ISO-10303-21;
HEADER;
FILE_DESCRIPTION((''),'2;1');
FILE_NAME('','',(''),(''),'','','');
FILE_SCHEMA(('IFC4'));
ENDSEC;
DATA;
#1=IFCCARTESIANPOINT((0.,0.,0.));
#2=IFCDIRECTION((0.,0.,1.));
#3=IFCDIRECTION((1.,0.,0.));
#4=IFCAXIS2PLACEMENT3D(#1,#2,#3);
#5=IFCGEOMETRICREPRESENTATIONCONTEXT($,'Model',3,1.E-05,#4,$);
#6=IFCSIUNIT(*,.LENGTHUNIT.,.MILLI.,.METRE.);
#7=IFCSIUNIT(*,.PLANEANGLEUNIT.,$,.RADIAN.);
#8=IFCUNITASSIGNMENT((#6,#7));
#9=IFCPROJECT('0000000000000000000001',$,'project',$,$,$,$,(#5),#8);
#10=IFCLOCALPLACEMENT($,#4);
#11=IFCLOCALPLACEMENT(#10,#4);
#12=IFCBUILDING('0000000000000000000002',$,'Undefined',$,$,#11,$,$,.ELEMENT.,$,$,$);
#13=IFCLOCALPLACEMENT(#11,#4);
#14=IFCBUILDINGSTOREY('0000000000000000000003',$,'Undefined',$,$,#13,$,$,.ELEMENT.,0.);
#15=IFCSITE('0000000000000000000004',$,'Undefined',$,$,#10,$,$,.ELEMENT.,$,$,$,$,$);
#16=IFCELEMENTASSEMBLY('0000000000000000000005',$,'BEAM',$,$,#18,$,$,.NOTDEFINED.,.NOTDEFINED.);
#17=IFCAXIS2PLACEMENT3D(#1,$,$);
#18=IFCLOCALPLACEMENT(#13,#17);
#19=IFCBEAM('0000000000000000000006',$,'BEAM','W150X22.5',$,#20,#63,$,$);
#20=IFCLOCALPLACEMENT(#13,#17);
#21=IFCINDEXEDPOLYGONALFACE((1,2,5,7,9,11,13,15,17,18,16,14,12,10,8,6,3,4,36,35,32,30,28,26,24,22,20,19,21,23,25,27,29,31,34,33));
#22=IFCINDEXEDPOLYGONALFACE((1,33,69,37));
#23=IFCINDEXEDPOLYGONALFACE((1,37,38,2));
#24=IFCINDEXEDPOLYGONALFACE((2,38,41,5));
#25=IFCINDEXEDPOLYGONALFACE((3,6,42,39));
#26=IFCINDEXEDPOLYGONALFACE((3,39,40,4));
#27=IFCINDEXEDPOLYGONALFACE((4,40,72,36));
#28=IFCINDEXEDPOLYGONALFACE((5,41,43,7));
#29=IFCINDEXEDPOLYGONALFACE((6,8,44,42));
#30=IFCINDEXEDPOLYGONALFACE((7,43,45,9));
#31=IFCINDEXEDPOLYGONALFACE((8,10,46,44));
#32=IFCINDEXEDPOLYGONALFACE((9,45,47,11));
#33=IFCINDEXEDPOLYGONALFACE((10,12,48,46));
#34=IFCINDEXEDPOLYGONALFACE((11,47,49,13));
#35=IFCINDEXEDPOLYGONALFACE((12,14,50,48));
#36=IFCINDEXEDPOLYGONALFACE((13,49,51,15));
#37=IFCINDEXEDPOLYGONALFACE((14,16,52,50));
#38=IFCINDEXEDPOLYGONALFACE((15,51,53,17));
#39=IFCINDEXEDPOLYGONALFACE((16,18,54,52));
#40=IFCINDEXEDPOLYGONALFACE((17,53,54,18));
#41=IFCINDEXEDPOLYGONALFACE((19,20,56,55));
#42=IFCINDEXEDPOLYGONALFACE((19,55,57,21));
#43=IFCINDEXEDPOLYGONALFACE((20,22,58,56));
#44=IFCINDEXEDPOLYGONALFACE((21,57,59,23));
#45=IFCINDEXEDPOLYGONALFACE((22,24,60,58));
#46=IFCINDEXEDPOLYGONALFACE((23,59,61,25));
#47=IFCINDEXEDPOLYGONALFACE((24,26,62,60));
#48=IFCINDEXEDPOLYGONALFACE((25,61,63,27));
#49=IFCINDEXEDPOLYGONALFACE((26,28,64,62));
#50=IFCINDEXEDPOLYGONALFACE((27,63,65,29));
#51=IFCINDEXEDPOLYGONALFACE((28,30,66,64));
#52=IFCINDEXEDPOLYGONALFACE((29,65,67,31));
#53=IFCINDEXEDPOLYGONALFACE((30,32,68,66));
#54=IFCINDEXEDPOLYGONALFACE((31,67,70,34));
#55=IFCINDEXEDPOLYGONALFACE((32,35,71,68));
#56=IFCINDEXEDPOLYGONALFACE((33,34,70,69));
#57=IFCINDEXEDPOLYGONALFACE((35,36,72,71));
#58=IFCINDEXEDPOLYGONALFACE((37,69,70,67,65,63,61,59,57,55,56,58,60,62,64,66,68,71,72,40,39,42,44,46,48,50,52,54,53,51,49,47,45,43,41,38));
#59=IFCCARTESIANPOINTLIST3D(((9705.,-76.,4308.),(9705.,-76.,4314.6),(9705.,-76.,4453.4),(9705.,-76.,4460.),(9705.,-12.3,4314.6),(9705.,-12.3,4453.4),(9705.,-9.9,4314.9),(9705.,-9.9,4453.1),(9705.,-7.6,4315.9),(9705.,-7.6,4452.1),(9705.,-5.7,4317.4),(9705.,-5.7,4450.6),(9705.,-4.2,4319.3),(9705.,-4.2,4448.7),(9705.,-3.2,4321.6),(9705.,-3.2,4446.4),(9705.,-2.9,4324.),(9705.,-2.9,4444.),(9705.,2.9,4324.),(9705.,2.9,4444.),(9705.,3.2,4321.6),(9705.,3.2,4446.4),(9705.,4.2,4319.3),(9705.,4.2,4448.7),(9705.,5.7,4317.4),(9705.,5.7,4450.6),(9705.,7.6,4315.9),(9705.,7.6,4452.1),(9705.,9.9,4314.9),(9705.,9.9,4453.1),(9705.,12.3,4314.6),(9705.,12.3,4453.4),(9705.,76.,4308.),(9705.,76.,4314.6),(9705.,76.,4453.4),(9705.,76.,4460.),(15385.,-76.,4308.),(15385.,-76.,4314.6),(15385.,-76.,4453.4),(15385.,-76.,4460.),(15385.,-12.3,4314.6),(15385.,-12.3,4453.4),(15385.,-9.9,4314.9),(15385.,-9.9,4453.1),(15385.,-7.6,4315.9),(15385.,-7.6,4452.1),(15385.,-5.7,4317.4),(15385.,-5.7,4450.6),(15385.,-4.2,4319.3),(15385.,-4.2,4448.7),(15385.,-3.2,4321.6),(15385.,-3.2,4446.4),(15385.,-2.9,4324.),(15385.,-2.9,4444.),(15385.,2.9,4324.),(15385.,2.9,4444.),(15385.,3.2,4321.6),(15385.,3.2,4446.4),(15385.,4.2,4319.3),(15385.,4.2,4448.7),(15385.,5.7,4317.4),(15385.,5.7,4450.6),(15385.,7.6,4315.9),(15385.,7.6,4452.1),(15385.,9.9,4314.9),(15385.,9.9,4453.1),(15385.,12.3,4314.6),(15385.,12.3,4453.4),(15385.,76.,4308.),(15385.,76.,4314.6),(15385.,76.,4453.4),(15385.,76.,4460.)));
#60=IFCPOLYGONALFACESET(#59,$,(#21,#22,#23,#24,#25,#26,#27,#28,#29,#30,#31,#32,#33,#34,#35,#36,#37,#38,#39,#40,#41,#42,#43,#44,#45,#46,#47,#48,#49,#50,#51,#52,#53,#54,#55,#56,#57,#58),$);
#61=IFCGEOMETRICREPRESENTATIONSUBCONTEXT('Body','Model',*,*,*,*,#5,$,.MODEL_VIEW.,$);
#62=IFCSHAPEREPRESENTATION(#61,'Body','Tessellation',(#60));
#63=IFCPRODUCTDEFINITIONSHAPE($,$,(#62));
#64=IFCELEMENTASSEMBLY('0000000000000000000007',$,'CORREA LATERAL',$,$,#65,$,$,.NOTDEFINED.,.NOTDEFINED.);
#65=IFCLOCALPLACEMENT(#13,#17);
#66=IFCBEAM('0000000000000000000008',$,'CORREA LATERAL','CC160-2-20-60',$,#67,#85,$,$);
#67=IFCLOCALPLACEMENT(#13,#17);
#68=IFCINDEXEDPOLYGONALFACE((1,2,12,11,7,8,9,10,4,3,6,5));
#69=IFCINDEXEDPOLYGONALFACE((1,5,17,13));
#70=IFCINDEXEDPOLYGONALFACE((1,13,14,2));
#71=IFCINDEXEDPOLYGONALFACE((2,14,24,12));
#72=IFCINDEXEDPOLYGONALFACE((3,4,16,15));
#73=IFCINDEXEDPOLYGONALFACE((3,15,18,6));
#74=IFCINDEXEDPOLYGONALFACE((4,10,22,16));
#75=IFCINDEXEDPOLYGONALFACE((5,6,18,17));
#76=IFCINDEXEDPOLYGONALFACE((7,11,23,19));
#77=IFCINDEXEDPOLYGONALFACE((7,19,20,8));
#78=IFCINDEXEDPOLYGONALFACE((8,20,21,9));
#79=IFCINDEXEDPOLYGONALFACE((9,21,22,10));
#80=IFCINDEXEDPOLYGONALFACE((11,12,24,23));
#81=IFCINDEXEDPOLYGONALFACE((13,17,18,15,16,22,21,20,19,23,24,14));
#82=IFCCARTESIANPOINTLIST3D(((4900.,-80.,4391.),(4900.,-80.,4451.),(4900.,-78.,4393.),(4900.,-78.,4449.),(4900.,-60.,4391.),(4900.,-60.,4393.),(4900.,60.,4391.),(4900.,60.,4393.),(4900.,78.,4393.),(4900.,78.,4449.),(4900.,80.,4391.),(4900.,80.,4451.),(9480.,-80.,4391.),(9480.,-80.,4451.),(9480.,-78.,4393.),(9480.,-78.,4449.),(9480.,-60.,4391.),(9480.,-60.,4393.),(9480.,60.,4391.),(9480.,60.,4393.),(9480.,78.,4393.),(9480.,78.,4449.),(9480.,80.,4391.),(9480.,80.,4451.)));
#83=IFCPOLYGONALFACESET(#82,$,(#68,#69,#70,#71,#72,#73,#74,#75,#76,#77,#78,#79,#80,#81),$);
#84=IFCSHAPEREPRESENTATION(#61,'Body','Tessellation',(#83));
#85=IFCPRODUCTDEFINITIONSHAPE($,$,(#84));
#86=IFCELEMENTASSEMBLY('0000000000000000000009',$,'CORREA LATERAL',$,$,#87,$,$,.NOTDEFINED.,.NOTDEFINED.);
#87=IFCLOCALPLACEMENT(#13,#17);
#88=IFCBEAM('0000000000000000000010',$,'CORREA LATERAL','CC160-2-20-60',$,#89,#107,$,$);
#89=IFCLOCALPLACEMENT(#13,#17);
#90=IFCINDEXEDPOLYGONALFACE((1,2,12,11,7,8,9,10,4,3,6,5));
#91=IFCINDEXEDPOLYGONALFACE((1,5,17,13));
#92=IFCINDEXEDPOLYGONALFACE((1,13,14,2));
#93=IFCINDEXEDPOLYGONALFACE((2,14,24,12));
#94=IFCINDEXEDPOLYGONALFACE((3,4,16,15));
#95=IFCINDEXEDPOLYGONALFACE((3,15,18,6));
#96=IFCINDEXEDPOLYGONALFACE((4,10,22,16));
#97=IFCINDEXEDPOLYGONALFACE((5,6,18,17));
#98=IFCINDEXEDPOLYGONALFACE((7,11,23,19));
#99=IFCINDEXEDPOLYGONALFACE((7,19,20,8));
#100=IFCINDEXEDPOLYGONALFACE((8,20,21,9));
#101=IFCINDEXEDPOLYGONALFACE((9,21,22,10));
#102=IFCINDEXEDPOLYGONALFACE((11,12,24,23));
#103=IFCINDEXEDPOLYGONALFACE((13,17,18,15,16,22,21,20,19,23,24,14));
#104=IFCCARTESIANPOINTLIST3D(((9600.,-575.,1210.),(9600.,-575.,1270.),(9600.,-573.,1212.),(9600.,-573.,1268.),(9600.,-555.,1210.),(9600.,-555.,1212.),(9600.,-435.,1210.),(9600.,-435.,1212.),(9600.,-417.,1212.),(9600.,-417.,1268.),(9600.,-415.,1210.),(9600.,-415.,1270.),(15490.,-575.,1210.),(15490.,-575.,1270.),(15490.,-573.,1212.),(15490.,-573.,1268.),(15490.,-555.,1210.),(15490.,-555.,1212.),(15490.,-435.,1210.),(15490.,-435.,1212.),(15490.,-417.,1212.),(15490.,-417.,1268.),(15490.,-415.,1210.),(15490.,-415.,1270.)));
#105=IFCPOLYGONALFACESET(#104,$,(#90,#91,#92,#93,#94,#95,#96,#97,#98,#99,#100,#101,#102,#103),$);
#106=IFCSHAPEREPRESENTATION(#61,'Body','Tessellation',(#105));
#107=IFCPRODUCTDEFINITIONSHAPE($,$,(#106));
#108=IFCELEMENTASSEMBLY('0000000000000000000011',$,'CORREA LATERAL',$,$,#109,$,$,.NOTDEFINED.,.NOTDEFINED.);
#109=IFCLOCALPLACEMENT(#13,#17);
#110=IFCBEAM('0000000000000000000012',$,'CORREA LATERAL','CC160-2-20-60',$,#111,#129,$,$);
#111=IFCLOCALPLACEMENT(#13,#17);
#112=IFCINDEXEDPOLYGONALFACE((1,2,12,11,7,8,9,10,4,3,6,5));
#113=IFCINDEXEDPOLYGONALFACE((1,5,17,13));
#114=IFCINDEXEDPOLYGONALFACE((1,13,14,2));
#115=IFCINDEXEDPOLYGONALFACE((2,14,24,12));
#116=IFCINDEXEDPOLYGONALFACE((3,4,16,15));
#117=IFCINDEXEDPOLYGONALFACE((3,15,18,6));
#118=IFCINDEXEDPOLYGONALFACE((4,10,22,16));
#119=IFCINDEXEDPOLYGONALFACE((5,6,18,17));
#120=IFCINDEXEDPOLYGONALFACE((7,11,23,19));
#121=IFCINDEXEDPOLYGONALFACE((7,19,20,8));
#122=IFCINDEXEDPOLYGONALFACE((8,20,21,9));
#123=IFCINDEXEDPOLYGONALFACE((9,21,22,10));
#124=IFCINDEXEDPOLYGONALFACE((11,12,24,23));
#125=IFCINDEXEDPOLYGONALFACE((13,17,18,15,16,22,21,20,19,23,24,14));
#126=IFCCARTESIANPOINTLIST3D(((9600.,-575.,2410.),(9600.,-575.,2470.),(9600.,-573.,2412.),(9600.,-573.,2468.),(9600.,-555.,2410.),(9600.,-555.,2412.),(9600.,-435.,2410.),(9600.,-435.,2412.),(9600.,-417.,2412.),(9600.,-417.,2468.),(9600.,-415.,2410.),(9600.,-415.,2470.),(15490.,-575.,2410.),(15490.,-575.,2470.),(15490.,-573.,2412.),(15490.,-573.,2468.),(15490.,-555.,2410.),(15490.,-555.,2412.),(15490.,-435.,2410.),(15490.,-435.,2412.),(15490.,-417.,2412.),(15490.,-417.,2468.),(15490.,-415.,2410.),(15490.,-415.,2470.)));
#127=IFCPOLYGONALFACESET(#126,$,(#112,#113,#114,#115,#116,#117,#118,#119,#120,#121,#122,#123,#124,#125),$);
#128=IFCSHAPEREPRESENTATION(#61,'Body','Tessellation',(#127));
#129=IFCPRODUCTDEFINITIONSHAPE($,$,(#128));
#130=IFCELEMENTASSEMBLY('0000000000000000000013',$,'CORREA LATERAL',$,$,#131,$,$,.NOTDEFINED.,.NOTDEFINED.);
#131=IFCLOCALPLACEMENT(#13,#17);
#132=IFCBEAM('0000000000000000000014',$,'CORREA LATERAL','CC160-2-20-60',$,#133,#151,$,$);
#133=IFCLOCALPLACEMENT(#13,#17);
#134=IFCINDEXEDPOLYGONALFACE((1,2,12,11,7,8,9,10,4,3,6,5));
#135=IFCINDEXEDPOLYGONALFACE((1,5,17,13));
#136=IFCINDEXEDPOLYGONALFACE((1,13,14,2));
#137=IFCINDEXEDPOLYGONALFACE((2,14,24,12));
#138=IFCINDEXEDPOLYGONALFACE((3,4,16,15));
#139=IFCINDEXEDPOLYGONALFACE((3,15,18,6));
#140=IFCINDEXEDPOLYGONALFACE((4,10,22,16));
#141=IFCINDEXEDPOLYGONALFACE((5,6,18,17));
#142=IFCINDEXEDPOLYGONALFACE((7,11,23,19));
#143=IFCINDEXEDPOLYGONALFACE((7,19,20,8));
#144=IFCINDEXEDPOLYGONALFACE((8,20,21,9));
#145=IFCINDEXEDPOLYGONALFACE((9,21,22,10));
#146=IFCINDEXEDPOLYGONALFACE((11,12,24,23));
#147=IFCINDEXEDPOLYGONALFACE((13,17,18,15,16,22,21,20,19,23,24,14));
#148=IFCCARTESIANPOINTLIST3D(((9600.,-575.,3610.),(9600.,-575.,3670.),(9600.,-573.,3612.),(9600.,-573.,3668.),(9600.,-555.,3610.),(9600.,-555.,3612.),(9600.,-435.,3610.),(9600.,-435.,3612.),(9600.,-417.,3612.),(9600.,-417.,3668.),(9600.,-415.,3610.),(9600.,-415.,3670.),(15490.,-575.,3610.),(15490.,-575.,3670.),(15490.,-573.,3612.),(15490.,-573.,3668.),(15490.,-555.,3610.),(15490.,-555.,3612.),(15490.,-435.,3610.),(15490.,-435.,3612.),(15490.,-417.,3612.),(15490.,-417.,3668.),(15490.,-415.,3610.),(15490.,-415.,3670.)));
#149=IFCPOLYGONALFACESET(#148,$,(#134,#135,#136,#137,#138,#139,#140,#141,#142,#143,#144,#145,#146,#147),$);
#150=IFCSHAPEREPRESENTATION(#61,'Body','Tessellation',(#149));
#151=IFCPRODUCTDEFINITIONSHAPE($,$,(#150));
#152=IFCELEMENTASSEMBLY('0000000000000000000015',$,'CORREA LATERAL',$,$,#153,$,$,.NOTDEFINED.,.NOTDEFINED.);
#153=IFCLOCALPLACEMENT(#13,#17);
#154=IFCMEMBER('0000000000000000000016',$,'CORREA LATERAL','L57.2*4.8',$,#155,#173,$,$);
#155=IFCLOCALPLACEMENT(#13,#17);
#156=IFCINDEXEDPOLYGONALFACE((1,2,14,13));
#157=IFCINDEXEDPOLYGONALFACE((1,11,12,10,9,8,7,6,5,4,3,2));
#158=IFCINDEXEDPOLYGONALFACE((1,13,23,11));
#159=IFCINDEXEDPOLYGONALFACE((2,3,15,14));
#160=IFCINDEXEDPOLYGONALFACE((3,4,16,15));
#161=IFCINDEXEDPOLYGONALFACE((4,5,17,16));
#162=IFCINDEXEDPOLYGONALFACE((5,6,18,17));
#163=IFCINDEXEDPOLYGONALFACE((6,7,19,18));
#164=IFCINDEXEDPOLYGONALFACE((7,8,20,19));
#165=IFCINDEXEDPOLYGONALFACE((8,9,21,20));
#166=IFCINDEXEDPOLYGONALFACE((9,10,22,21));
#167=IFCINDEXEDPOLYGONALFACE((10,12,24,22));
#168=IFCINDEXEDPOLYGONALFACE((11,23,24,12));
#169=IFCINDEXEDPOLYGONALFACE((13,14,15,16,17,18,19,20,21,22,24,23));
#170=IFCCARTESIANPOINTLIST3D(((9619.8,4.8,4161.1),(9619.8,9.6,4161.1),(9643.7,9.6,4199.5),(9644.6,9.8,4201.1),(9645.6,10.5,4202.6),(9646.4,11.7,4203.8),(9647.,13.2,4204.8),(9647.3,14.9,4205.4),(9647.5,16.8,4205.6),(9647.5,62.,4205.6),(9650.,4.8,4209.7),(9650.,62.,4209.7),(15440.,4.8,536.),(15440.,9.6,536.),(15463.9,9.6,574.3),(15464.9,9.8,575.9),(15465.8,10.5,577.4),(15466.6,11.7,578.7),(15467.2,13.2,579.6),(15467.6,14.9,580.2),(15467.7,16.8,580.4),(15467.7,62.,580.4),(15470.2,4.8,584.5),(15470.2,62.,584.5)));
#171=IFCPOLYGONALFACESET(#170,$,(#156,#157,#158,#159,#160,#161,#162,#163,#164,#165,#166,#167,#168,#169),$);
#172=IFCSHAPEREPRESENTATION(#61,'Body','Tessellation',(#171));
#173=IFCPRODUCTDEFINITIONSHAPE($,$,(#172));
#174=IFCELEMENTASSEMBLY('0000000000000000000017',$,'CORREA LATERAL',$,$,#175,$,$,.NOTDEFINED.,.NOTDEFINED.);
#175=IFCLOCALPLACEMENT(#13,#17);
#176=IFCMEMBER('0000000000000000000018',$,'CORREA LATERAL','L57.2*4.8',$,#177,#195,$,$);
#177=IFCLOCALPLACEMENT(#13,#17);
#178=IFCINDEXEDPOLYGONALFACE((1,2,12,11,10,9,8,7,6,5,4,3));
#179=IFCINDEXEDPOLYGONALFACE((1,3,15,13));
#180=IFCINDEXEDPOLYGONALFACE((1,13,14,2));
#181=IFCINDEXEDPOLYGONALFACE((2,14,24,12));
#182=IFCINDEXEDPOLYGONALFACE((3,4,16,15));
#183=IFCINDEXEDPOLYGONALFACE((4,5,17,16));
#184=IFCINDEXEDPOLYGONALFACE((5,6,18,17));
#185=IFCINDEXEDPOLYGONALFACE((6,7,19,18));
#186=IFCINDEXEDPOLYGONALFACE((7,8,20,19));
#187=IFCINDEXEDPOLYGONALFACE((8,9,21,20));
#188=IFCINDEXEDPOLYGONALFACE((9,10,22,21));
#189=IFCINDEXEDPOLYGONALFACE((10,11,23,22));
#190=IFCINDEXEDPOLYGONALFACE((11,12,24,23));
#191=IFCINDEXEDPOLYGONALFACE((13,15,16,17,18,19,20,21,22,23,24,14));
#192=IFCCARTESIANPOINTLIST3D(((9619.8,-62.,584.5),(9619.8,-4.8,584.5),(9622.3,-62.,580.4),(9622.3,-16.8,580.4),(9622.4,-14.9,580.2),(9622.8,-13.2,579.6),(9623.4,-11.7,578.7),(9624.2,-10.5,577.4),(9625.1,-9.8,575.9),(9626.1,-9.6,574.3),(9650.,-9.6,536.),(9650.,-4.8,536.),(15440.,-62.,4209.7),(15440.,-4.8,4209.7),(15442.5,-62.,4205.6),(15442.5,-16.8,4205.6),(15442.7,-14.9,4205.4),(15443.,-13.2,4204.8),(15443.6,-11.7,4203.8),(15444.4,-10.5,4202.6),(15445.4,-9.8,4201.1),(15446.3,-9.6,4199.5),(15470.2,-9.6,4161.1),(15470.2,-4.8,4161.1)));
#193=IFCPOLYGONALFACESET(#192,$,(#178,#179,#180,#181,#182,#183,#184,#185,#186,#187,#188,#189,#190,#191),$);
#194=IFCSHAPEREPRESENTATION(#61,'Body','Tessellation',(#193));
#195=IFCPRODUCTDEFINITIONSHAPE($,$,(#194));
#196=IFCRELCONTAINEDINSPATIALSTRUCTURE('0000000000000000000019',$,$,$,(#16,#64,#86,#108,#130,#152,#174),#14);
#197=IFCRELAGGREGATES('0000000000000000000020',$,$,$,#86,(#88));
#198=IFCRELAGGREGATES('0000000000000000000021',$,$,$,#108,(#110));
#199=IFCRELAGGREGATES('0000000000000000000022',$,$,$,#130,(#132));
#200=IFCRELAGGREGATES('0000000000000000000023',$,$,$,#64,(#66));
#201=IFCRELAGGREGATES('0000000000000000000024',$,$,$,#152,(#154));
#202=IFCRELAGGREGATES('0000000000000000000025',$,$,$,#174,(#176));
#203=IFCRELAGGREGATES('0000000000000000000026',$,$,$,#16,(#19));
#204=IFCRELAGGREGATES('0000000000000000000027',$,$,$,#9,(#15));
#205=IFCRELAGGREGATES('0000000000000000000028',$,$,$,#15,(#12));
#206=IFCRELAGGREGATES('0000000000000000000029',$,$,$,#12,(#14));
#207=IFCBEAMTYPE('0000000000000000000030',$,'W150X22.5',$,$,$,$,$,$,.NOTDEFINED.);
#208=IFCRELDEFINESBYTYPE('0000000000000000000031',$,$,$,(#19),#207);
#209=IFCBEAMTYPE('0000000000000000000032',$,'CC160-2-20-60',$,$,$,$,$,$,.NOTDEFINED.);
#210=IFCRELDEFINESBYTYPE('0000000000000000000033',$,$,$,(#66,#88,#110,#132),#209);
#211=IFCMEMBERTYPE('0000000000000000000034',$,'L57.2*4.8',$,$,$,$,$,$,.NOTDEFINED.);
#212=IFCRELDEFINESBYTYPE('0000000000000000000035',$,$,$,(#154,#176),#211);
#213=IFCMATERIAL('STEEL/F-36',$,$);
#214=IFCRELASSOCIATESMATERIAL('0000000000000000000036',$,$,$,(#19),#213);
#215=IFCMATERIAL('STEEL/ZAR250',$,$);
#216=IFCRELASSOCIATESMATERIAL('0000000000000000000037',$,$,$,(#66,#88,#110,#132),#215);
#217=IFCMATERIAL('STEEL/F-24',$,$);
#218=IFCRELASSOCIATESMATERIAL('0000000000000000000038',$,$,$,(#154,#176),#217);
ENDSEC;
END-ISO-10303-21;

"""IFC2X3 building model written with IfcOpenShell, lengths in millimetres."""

from ifc_helpers import new_model, si_unit, frame, origin_with_axes, origin_2d_with_axis, place, context, subcontext, project, spatial, i_section, l_section, c_section, extrude, clip, halfspace, material, type_object, element, aggregate, save


model = new_model("IFC2X3")

# Units and contexts
model_context = context("Model", 3, precision=1e-05, world=origin_with_axes())
body_context = subcontext(model_context, "Body", "Model", "MODEL_VIEW")
ifc_project = project(units=[si_unit("LENGTHUNIT", "METRE", prefix="MILLI"), si_unit("PLANEANGLEUNIT", "RADIAN")], contexts=[model_context])

# Site, building, storey
site_placement = place(None, origin_with_axes())
site = spatial("IfcSite", under=ifc_project, at=site_placement, Name="Undefined", CompositionType="ELEMENT")
building_placement = place(site_placement, origin_with_axes())
building = spatial("IfcBuilding", under=site, at=building_placement, Name="Undefined", CompositionType="ELEMENT")
storey_placement = place(building_placement, origin_with_axes())
storey = spatial("IfcBuildingStorey", under=building, at=storey_placement, Name="Undefined", CompositionType="ELEMENT", Elevation=0.0)

# Shared definitions
ifc_material_1 = material(Name="STEEL/F-36")

# Element assemblies, beams
assembly_1_placement = place(storey_placement, origin_with_axes())
assembly_1 = element("IfcElementAssembly", 1, at=assembly_1_placement, inside=storey, Name="BEAM", AssemblyPlace="NOTDEFINED", PredefinedType="NOTDEFINED")
beam_type_1 = type_object("IfcBeamType", Name="W150X22.5", PredefinedType="NOTDEFINED")
beam_1_placement = place(assembly_1_placement, frame((9705.0, 0.0, 4384.0), z_axis=(0.0, 0.0, 1.0), x_axis=(1.0, 0.0, 0.0)))
beam_1 = element("IfcBeam", 2, at=beam_1_placement, type_object=beam_type_1, material=ifc_material_1, Name="BEAM", Description="W150X22.5", context=body_context, shape_type="SweptSolid", body=[
    extrude(i_section(OverallWidth=152.0, OverallDepth=152.0, WebThickness=5.8, FlangeThickness=6.6, FilletRadius=9.4, at=origin_2d_with_axis()), frame((5680.0, 0.0, 0.0), z_axis=(-1.0, 0.0, 0.0), x_axis=(0.0, -1.0, 0.0)), (0.0, 0.0, 1.0), 5680.0),
])
assembly_2_placement = place(storey_placement, origin_with_axes())
assembly_2 = element("IfcElementAssembly", 3, at=assembly_2_placement, inside=storey, Name="CORREA LATERAL", AssemblyPlace="NOTDEFINED", PredefinedType="NOTDEFINED")
ifc_material_2 = material(Name="STEEL/ZAR250")
beam_type_2 = type_object("IfcBeamType", Name="CC160-2-20-60", PredefinedType="NOTDEFINED")
beam_2_placement = place(assembly_2_placement, frame((9480.0, 0.0, 4421.0), z_axis=(0.0, 1.0, 0.0), x_axis=(-1.0, 0.0, 0.0)))
beam_2 = element("IfcBeam", 4, at=beam_2_placement, type_object=beam_type_2, material=ifc_material_2, Name="CORREA LATERAL", Description="CC160-2-20-60", context=body_context, shape_type="SweptSolid", body=[
    extrude(c_section(Depth=160.0, Width=60.0, WallThickness=2.0, Girth=20.0, at=origin_2d_with_axis()), frame((4580.0, 0.0, 0.0), z_axis=(-1.0, 0.0, 0.0), x_axis=(0.0, -1.0, 0.0)), (0.0, 0.0, 1.0), 4580.0),
])
assembly_3_placement = place(storey_placement, origin_with_axes())
assembly_3 = element("IfcElementAssembly", 5, at=assembly_3_placement, inside=storey, Name="CORREA LATERAL", AssemblyPlace="NOTDEFINED", PredefinedType="NOTDEFINED")
beam_3_placement = place(assembly_3_placement, frame((9600.0, -495.0, 1240.0), z_axis=(0.0, -1.0, 0.0), x_axis=(1.0, 0.0, 0.0)))
beam_3 = element("IfcBeam", 6, at=beam_3_placement, type_object=beam_type_2, material=ifc_material_2, Name="CORREA LATERAL", Description="CC160-2-20-60", context=body_context, shape_type="SweptSolid", body=[
    extrude(c_section(Depth=160.0, Width=60.0, WallThickness=2.0, Girth=20.0, at=origin_2d_with_axis()), frame((5890.0, 0.0, 0.0), z_axis=(-1.0, 0.0, 0.0), x_axis=(0.0, -1.0, 0.0)), (0.0, 0.0, 1.0), 5890.0),
])
aggregate(assembly_3, [beam_3])
assembly_4_placement = place(storey_placement, origin_with_axes())
assembly_4 = element("IfcElementAssembly", 7, at=assembly_4_placement, inside=storey, Name="CORREA LATERAL", AssemblyPlace="NOTDEFINED", PredefinedType="NOTDEFINED")
beam_4_placement = place(assembly_4_placement, frame((9600.0, -495.0, 2440.0), z_axis=(0.0, -1.0, 0.0), x_axis=(1.0, 0.0, 0.0)))
beam_4 = element("IfcBeam", 8, at=beam_4_placement, type_object=beam_type_2, material=ifc_material_2, Name="CORREA LATERAL", Description="CC160-2-20-60", context=body_context, shape_type="SweptSolid", body=[
    extrude(c_section(Depth=160.0, Width=60.0, WallThickness=2.0, Girth=20.0, at=origin_2d_with_axis()), frame((5890.0, 0.0, 0.0), z_axis=(-1.0, 0.0, 0.0), x_axis=(0.0, -1.0, 0.0)), (0.0, 0.0, 1.0), 5890.0),
])
aggregate(assembly_4, [beam_4])
assembly_5_placement = place(storey_placement, origin_with_axes())
assembly_5 = element("IfcElementAssembly", 9, at=assembly_5_placement, inside=storey, Name="CORREA LATERAL", AssemblyPlace="NOTDEFINED", PredefinedType="NOTDEFINED")
beam_5_placement = place(assembly_5_placement, frame((9600.0, -495.0, 3640.0), z_axis=(0.0, -1.0, 0.0), x_axis=(1.0, 0.0, 0.0)))
beam_5 = element("IfcBeam", 10, at=beam_5_placement, type_object=beam_type_2, material=ifc_material_2, Name="CORREA LATERAL", Description="CC160-2-20-60", context=body_context, shape_type="SweptSolid", body=[
    extrude(c_section(Depth=160.0, Width=60.0, WallThickness=2.0, Girth=20.0, at=origin_2d_with_axis()), frame((5890.0, 0.0, 0.0), z_axis=(-1.0, 0.0, 0.0), x_axis=(0.0, -1.0, 0.0)), (0.0, 0.0, 1.0), 5890.0),
])
aggregate(assembly_5, [beam_5])

# Element assemblies, members
ifc_material_3 = material(Name="STEEL/F-24")
member_type = type_object("IfcMemberType", Name="L57.2*4.8", PredefinedType="NOTDEFINED")
assembly_6_placement = place(storey_placement, origin_with_axes())
assembly_6 = element("IfcElementAssembly", 11, at=assembly_6_placement, inside=storey, Name="CORREA LATERAL", AssemblyPlace="NOTDEFINED", PredefinedType="NOTDEFINED")
member_1_placement = place(assembly_6_placement, frame((9634.9, 33.4, 4185.4), z_axis=(-0.528689, 0.0, -0.848815), x_axis=(0.848815, 0.0, -0.528689)))
member_1 = element("IfcMember", 12, at=member_1_placement, type_object=member_type, material=ifc_material_3, Name="CORREA LATERAL", Description="L57.2*4.8", context=body_context, shape_type="Clipping", body=[
    clip(clip(extrude(l_section(Depth=57.2, Width=57.2, Thickness=4.8, FilletRadius=7.2, at=origin_2d_with_axis()), frame((6908.7, 0.0, 0.0), z_axis=(-1.0, 0.0, 0.0), x_axis=(0.0, -1.0, 0.0)), (0.0, 0.0, 1.0), 6960.6), halfspace(frame((6856.9, 38.1, 0.0), z_axis=(-1.0, 0.0, 0.0), x_axis=(0.0, 0.0, 1.0)), True)), halfspace(frame((0.0, 38.1, 0.0), z_axis=(1.0, 0.0, 0.0), x_axis=(0.0, 0.0, -1.0)), True)),
])
assembly_7_placement = place(storey_placement, origin_with_axes())
assembly_7 = element("IfcElementAssembly", 13, at=assembly_7_placement, inside=storey, Name="CORREA LATERAL", AssemblyPlace="NOTDEFINED", PredefinedType="NOTDEFINED")
member_2_placement = place(assembly_7_placement, frame((9634.9, -33.4, 560.2), z_axis=(0.0, -1.0, 0.0), x_axis=(0.848815, 0.0, 0.528689)))
member_2 = element("IfcMember", 14, at=member_2_placement, type_object=member_type, material=ifc_material_3, Name="CORREA LATERAL", Description="L57.2*4.8", context=body_context, shape_type="Clipping", body=[
    clip(clip(extrude(l_section(Depth=57.2, Width=57.2, Thickness=4.8, FilletRadius=7.2, at=origin_2d_with_axis()), frame((6908.7, 0.0, 0.0), z_axis=(-1.0, 0.0, 0.0), x_axis=(0.0, -1.0, 0.0)), (0.0, 0.0, 1.0), 6960.6), halfspace(frame((6856.9, 0.0, -28.6), z_axis=(-1.0, 0.0, 0.0), x_axis=(0.0, -1.0, 0.0)), True)), halfspace(frame((0.0, 0.0, -28.6), z_axis=(1.0, 0.0, 0.0), x_axis=(0.0, 1.0, 0.0)), True)),
])

aggregate(assembly_2, [beam_2])
aggregate(assembly_6, [member_1])
aggregate(assembly_7, [member_2])
aggregate(assembly_1, [beam_1])

save(model, "model.ifc")
